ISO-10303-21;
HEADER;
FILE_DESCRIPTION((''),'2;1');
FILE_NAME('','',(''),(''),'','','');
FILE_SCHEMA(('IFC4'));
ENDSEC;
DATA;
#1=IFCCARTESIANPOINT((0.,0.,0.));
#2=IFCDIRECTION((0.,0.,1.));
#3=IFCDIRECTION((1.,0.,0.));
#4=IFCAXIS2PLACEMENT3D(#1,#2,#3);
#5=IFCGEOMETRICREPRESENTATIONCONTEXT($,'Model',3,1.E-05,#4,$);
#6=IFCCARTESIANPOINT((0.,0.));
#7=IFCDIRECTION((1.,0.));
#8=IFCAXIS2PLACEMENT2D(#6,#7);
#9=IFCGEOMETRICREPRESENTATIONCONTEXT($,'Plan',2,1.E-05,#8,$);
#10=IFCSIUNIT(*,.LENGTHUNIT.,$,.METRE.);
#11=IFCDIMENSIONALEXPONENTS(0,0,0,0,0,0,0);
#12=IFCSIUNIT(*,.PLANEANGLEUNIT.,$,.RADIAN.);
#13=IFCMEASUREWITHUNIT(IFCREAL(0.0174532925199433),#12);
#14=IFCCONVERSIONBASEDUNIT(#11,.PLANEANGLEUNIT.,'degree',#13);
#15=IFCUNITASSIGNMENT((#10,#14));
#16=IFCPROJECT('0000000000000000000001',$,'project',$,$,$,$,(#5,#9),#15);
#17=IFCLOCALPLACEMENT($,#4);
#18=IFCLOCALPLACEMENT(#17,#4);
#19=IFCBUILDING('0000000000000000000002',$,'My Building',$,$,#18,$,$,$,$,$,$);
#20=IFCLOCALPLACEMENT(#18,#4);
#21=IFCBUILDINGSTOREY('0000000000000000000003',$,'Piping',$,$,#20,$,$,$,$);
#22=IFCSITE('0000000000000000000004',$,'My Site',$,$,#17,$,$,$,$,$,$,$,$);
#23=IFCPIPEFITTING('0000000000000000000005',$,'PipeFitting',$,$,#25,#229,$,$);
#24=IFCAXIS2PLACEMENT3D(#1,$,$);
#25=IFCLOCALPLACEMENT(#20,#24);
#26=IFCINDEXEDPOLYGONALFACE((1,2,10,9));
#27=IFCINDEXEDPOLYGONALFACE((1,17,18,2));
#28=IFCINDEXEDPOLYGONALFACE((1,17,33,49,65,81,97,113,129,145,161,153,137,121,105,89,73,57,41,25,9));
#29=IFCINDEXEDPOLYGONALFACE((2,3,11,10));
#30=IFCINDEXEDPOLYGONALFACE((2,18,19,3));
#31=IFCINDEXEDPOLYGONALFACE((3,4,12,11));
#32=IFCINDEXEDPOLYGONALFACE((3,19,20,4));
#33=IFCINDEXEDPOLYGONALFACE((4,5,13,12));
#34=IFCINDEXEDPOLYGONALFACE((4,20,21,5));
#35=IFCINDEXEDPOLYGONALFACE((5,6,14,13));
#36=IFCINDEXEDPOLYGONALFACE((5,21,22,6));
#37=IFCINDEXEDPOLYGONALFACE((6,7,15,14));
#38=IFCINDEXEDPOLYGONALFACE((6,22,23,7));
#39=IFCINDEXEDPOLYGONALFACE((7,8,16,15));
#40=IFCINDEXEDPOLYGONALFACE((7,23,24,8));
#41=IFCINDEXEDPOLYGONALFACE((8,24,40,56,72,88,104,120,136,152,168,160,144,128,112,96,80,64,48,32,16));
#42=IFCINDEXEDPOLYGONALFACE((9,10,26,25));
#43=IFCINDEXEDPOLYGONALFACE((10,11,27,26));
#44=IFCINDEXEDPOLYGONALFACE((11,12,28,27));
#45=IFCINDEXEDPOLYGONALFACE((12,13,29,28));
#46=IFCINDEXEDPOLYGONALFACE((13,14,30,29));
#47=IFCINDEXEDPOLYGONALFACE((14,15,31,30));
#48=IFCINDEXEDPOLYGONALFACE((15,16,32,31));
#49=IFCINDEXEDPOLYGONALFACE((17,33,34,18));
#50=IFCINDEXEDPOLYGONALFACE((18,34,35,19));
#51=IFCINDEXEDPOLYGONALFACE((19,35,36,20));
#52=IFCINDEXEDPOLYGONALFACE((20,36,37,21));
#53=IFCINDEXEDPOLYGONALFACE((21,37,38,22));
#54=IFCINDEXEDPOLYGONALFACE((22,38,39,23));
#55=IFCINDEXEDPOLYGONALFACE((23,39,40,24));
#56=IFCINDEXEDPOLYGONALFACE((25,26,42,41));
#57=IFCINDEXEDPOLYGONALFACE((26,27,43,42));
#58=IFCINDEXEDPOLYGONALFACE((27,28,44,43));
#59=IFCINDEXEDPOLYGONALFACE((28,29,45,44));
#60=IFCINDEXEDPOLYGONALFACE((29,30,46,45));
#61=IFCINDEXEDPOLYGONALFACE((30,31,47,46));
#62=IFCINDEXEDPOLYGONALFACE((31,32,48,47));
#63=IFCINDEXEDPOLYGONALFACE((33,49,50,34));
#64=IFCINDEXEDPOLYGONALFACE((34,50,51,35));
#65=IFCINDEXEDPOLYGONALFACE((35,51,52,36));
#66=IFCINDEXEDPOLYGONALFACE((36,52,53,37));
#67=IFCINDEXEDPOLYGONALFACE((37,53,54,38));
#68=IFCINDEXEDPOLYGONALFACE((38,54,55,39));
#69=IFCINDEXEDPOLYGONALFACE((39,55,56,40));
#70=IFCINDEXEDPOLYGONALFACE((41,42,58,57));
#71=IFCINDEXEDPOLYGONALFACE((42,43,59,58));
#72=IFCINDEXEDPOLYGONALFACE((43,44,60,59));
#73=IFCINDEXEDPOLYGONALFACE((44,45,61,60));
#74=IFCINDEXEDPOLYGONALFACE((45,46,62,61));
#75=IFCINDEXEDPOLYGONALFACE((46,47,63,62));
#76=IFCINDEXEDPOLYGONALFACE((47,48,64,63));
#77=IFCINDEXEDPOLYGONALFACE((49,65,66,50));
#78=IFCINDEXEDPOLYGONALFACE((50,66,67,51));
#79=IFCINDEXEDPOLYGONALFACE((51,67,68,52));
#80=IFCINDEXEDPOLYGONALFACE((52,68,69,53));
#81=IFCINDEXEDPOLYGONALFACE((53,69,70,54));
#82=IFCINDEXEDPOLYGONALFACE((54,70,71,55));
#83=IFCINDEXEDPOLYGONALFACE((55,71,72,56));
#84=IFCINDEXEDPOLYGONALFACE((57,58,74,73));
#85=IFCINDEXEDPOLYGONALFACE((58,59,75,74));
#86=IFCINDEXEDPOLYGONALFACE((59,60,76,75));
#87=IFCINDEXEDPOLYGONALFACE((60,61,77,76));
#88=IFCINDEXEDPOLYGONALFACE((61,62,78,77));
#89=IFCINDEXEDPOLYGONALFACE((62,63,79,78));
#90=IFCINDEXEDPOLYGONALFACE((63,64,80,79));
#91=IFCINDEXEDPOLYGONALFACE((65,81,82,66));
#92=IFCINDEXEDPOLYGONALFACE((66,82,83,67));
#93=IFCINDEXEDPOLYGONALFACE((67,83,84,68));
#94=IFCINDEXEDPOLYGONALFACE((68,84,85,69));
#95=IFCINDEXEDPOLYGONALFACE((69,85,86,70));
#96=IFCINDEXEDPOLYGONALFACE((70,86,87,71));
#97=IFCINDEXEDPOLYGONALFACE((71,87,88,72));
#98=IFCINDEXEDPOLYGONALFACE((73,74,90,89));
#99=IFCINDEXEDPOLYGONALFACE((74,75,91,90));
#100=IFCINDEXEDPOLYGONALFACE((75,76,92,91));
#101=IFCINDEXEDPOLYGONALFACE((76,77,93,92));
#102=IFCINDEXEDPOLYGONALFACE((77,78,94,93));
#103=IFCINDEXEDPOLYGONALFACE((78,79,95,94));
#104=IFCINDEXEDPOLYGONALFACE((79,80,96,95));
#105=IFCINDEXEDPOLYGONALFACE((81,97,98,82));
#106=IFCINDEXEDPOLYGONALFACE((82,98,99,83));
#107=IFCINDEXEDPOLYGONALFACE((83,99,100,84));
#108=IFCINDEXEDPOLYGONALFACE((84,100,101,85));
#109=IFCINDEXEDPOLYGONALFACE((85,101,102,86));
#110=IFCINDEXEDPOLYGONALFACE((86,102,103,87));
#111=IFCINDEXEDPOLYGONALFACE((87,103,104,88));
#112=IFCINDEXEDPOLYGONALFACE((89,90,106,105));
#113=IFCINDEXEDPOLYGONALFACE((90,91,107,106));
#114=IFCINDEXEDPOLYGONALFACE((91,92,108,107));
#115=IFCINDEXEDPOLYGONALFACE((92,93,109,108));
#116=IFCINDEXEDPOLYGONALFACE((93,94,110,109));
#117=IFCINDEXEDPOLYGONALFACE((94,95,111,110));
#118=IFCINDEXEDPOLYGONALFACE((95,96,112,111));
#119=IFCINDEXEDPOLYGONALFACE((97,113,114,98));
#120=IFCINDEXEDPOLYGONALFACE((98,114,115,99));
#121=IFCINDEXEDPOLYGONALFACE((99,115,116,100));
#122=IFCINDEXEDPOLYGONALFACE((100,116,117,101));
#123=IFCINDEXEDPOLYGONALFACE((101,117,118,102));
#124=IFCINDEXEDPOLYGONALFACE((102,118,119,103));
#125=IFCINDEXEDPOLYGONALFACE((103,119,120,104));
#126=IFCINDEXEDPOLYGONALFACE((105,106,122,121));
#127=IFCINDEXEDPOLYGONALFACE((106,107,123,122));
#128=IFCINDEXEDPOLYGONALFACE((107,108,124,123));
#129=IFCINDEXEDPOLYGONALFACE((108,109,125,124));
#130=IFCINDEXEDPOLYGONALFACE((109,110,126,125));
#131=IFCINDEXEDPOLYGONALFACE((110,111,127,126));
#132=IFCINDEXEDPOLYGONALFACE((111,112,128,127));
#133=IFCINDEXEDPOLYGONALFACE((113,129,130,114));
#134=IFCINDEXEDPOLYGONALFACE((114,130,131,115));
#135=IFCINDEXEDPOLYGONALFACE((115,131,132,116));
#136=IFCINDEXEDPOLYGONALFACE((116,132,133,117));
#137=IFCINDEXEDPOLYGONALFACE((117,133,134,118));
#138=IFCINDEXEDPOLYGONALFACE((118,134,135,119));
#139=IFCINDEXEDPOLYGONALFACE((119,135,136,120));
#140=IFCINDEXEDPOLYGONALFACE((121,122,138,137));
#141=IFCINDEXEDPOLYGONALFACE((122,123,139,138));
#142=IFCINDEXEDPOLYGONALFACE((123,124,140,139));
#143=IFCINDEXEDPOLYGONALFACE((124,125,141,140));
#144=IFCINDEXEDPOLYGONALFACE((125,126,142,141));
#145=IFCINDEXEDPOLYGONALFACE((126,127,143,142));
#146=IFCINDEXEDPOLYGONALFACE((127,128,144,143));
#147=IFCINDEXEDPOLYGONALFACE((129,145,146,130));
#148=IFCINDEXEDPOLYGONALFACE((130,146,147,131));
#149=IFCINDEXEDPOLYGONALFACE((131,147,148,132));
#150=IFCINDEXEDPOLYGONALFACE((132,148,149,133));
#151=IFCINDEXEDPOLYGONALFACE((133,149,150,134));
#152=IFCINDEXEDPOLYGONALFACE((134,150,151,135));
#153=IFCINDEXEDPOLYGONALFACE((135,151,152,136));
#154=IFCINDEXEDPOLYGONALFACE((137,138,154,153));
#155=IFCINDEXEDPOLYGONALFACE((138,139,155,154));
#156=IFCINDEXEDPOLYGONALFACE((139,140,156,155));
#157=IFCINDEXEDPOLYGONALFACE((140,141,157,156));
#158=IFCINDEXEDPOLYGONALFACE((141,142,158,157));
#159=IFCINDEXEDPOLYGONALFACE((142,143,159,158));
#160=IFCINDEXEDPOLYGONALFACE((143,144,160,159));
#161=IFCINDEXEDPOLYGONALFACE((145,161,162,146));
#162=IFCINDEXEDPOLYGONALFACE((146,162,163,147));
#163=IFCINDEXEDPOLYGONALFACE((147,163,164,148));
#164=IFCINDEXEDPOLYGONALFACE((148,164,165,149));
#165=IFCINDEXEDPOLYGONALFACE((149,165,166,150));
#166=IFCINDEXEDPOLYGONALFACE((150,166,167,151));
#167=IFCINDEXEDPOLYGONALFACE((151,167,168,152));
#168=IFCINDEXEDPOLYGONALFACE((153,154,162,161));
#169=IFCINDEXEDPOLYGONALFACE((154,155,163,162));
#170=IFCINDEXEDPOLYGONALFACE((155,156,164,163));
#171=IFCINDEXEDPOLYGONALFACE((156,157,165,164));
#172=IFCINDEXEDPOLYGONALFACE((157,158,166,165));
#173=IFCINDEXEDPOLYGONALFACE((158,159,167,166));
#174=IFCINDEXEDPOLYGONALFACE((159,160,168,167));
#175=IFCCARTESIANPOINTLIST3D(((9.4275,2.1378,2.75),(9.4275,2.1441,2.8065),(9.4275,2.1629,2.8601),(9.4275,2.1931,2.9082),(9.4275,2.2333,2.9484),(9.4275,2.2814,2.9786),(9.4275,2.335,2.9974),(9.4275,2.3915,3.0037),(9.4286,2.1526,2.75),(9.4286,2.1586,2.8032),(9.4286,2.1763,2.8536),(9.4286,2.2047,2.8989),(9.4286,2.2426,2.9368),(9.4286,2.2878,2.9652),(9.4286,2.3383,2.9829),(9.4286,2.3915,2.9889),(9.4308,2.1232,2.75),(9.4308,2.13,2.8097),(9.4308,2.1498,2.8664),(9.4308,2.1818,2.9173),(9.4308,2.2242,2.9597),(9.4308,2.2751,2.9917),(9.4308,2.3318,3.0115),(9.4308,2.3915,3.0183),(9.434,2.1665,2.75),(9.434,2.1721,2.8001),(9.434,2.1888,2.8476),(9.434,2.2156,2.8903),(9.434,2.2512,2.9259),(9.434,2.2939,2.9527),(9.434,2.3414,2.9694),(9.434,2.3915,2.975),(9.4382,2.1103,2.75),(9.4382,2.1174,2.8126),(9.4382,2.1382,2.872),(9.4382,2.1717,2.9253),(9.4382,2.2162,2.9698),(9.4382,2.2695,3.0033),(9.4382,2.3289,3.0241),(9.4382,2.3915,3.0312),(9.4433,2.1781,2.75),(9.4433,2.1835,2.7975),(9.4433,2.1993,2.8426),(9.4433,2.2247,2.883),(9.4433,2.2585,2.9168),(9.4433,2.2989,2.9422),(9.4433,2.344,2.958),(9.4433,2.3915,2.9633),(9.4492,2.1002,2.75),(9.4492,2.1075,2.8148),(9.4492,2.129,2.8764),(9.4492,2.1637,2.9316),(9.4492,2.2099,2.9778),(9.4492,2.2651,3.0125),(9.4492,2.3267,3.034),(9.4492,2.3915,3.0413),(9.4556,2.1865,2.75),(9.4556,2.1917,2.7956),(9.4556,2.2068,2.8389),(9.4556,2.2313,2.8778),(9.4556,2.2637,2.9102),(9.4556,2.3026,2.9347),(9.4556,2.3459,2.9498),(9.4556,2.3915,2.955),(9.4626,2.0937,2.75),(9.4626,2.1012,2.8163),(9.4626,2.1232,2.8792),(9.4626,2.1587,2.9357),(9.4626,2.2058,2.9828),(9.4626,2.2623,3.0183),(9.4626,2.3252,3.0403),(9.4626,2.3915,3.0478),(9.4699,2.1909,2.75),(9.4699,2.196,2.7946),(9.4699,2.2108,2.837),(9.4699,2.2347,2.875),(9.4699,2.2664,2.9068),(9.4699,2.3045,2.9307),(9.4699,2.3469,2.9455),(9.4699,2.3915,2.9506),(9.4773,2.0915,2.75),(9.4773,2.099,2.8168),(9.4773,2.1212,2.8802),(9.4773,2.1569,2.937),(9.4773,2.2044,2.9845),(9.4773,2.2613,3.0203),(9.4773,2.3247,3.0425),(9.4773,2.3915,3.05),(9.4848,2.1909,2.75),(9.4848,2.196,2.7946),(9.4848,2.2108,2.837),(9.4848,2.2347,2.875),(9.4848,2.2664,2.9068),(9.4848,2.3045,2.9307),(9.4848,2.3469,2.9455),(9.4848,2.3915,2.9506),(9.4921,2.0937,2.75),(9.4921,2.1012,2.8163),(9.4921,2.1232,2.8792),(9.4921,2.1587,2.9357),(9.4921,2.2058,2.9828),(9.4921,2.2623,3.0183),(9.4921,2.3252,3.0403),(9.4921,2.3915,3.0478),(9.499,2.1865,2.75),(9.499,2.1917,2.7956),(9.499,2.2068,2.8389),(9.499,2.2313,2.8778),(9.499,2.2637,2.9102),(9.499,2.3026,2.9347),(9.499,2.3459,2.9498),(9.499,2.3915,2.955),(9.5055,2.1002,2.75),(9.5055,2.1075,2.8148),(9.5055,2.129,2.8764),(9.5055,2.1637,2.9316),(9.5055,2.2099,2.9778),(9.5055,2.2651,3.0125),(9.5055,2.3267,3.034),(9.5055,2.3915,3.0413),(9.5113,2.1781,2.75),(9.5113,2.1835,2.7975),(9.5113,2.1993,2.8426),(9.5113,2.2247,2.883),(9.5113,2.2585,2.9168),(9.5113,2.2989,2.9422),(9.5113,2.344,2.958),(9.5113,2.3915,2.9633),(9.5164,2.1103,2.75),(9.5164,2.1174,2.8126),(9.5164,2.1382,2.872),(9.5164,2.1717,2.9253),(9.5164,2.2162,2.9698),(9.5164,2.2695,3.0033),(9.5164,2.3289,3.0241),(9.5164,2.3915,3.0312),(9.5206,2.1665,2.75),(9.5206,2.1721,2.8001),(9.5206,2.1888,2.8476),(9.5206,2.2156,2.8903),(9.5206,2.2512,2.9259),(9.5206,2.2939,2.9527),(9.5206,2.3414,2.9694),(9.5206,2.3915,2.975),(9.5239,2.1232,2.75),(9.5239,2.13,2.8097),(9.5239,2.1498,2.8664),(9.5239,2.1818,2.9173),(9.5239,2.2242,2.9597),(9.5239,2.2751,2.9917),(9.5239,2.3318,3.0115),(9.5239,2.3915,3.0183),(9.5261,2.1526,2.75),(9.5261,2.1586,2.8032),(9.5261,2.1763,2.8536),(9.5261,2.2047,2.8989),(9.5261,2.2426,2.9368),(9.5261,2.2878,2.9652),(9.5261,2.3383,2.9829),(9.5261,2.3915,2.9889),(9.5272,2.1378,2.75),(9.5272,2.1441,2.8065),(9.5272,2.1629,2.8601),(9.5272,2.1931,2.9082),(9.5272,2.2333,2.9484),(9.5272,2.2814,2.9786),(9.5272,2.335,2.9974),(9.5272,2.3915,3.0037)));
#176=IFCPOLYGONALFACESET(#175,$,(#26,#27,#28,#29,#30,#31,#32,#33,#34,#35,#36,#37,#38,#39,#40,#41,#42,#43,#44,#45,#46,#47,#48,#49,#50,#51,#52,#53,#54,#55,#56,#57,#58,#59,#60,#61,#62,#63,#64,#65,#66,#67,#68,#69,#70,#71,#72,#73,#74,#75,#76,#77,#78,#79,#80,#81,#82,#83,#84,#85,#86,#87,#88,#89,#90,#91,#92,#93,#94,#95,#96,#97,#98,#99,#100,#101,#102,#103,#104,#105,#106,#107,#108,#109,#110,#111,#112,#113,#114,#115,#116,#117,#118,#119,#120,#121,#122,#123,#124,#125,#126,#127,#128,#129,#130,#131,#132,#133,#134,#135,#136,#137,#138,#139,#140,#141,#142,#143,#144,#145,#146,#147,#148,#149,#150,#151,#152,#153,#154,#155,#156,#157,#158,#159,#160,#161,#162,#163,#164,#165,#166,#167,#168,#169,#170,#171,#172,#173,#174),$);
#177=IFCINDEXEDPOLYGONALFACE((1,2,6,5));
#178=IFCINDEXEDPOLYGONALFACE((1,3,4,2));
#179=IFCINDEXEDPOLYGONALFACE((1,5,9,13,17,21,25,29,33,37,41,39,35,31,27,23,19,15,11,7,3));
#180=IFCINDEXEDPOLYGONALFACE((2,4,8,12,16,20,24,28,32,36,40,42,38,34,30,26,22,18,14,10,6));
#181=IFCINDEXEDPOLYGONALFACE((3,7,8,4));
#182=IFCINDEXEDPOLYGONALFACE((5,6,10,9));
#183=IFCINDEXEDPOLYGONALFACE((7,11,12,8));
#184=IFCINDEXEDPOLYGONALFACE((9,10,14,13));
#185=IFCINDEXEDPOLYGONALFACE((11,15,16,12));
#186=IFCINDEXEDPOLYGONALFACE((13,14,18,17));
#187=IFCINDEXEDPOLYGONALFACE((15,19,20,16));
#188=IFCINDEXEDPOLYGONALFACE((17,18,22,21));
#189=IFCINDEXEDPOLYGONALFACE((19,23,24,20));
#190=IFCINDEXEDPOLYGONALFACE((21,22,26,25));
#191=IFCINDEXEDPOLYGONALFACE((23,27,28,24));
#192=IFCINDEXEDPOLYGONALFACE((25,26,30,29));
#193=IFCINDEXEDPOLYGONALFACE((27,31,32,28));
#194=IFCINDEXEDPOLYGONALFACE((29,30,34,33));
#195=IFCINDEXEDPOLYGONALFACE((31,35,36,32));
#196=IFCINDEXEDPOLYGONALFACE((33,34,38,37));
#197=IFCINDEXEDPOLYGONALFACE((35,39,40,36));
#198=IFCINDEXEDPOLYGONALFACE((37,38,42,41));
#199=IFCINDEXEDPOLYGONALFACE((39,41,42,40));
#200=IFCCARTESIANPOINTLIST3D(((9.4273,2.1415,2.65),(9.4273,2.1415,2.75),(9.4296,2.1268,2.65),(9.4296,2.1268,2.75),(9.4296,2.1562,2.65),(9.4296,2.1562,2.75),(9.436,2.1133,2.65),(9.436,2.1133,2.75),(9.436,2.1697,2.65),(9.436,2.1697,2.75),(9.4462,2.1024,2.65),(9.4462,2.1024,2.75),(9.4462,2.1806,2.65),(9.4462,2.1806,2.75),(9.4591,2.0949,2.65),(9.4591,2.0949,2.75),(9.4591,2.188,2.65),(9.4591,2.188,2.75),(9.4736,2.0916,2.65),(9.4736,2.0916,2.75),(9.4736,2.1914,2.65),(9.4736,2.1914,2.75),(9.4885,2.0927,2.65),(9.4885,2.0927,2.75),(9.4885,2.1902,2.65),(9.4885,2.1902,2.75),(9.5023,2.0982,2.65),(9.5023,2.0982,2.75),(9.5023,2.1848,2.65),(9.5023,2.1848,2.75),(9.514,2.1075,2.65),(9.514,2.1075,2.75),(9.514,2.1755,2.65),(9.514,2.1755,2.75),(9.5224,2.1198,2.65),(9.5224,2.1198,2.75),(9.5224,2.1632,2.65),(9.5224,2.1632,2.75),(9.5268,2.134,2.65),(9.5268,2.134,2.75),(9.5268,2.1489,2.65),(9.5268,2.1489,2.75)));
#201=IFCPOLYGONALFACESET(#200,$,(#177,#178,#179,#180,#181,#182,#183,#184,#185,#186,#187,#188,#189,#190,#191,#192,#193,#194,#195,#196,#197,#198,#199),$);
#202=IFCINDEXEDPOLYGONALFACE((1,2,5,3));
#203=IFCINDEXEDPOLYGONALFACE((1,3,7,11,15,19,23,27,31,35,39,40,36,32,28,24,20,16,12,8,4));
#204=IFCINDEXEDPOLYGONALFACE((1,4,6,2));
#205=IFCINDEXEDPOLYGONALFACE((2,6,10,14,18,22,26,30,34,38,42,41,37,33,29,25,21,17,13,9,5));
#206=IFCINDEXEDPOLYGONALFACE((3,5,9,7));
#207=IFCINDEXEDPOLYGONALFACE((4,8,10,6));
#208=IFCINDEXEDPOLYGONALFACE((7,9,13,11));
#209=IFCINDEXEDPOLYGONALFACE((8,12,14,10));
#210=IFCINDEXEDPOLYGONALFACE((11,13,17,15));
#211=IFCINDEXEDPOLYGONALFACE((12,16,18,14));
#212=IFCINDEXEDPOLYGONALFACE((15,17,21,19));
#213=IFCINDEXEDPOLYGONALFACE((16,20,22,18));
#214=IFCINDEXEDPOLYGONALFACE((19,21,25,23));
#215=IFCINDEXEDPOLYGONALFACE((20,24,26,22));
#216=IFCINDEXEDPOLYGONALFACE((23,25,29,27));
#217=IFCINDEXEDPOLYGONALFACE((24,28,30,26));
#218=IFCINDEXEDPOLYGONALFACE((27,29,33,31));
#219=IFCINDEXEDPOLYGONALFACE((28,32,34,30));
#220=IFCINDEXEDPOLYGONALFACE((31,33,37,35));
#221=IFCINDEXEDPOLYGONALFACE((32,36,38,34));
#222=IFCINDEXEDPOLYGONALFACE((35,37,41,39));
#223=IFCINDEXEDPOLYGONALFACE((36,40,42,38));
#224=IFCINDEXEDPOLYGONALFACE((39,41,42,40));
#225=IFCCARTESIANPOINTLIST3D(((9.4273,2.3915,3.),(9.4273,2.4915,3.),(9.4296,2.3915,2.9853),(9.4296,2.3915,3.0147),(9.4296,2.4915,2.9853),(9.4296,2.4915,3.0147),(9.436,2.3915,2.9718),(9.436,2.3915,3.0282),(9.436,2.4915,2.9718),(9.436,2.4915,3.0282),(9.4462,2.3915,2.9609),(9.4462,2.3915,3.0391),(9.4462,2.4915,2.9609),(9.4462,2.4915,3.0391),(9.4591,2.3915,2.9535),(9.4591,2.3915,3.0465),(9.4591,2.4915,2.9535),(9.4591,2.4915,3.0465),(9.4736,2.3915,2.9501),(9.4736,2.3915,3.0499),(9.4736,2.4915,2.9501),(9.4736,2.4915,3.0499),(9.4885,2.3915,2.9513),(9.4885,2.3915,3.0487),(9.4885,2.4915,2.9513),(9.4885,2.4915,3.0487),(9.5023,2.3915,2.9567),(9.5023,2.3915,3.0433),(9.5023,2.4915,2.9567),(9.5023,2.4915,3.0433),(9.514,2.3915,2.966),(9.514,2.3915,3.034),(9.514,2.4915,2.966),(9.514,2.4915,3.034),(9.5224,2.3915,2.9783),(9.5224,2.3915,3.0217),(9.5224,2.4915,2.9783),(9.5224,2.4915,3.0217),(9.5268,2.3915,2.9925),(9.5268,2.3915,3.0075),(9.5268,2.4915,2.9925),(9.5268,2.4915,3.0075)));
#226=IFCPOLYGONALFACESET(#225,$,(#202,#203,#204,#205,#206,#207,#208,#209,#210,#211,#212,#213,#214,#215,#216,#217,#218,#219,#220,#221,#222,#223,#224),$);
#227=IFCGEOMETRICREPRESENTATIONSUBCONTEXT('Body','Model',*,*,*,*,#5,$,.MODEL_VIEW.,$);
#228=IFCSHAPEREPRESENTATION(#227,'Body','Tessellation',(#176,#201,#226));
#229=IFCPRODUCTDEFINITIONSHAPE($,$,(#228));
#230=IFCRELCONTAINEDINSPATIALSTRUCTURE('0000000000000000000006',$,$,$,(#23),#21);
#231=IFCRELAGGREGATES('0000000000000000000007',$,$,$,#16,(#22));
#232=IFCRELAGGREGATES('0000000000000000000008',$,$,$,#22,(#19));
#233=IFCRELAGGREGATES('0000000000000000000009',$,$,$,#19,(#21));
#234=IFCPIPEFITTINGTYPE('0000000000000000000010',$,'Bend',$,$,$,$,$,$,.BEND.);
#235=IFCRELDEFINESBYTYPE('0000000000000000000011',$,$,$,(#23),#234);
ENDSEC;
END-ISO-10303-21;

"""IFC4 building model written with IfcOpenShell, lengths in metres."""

from ifc_helpers import new_model, entity, si_unit, converted_unit, frame, origin_with_axes, origin_2d_with_axis, place, context, subcontext, project, spatial, circle, extrude, source, transform, mapped, type_object, type_shapes, element, save


model = new_model("IFC4")

# Units and contexts
model_context = context("Model", 3, precision=1e-05, world=origin_with_axes())
plan_context = context("Plan", 2, precision=1e-05, world=origin_2d_with_axis())
body_context = subcontext(model_context, "Body", "Model", "MODEL_VIEW")
ifc_project = project(units=[si_unit("LENGTHUNIT", "METRE"), converted_unit("PLANEANGLEUNIT", "degree", entity("IfcReal", 0.0174532925199433), si_unit("PLANEANGLEUNIT", "RADIAN"), dimensions=[0, 0, 0, 0, 0, 0, 0])], contexts=[model_context, plan_context])

# Site, building, storey
site_placement = place(None, origin_with_axes())
site = spatial("IfcSite", under=ifc_project, at=site_placement, Name="My Site")
building_placement = place(site_placement, origin_with_axes())
building = spatial("IfcBuilding", under=site, at=building_placement, Name="My Building")
storey_placement = place(building_placement, origin_with_axes())
storey = spatial("IfcBuildingStorey", under=building, at=storey_placement, Name="Piping")

# Pipe fitting
pipe_fitting_type_1 = type_object("IfcPipeFittingType", Name="Bend", PredefinedType="BEND")
shared_shape = source(origin_with_axes(), body_context, "Body", "SolidModel", [
    entity("IfcSweptDiskSolid", entity("IfcIndexedPolyCurve", entity("IfcCartesianPointList3D", [[0.0, 0.0, -0.1], [0.0, 0.0732, -0.2768], [0.0, 0.25, -0.35]]), [entity("IfcArcIndex", [1, 2, 3])]), 0.05),
    extrude(circle(Radius=0.05), origin_with_axes(), (0.0, 0.0, -1.0), 0.1),
    extrude(circle(Radius=0.05), frame((0.0, 0.25, -0.35), z_axis=(0.0, 1.0, 0.0), x_axis=(1.0, 0.0, 0.0)), (0.0, 0.0, 1.0), 0.1),
])
type_shapes(pipe_fitting_type_1, [shared_shape])
for number, where, z_axis, x_axis, name in (
    (1, (9.4773, 2.1415, 2.65), (0.0, 0.0, -1.0), (-1.0, 0.0, 0.0), "PipeFitting"),
):
    element("IfcPipeFitting", number, at=place(storey_placement, frame(where, z_axis=z_axis, x_axis=x_axis)), inside=storey, type_object=pipe_fitting_type_1, Name=name, context=body_context, shape_type="MappedRepresentation", body=[
        mapped(shared_shape, transform((0.0, 0.0, 0.0), x_axis=(1.0, 0.0, 0.0), y_axis=(0.0, 1.0, 0.0), z_axis=(0.0, 0.0, 1.0), scale=1.0)),
    ])

save(model, "model.ifc")
